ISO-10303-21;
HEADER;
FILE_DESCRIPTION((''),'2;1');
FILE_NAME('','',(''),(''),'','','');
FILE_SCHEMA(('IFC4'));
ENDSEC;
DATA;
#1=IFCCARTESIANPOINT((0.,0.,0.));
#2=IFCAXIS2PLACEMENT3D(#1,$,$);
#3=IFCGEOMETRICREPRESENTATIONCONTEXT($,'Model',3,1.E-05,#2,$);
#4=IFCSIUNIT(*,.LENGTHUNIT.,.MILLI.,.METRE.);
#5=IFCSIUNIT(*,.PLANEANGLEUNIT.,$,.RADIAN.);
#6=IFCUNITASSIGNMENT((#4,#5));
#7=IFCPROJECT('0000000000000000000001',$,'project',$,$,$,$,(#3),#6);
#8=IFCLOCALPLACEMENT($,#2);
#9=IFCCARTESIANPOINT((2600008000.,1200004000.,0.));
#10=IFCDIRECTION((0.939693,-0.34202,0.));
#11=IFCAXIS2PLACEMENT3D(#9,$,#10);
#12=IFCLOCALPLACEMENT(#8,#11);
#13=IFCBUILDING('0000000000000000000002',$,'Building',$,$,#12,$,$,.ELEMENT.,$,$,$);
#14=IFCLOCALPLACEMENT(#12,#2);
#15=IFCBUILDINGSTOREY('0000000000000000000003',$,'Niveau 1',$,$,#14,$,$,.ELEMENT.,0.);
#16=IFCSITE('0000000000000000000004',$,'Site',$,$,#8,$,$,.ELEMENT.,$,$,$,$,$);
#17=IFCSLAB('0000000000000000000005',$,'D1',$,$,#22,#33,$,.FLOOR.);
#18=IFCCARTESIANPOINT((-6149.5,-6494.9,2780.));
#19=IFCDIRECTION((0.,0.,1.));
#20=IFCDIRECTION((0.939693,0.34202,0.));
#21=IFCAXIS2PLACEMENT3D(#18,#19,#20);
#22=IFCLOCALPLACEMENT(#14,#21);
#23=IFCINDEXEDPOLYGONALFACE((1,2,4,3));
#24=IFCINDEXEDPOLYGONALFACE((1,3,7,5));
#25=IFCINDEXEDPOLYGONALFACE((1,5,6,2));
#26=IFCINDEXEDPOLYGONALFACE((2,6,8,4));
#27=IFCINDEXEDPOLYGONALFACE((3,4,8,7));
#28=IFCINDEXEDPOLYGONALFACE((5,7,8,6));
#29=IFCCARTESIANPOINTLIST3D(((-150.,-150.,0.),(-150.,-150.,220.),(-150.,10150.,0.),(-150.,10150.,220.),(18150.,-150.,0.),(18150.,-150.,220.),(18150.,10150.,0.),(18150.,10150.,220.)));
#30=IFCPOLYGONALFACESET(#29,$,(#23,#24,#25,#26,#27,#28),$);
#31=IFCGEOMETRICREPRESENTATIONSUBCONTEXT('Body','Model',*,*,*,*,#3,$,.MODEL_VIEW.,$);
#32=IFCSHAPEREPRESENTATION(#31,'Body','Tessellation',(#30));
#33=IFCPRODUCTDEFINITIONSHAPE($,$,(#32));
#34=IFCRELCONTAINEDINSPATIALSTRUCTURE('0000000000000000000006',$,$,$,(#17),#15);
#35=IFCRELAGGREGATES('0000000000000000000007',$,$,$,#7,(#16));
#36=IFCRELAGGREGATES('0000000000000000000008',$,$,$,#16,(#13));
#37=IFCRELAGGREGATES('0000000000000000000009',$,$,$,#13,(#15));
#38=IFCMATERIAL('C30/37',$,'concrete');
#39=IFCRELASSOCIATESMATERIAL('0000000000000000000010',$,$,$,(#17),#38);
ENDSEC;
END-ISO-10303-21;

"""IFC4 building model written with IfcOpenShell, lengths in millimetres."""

from ifc_helpers import new_model, si_unit, frame, origin, place, context, subcontext, project, spatial, polyline, outline, extrude, material, element, save


model = new_model("IFC4")

# Units and contexts
model_context = context("Model", 3, precision=1e-05, world=origin())
body_context = subcontext(model_context, "Body", "Model", "MODEL_VIEW")
ifc_project = project(units=[si_unit("LENGTHUNIT", "METRE", prefix="MILLI"), si_unit("PLANEANGLEUNIT", "RADIAN")], contexts=[model_context])

# Site, building, storey
site_placement = place(None, origin())
site = spatial("IfcSite", under=ifc_project, at=site_placement, Name="Site", CompositionType="ELEMENT")
building_placement = place(site_placement, frame((2600008000.0, 1200004000.0, 0.0), x_axis=(0.939693, -0.34202, 0.0)))
building = spatial("IfcBuilding", under=site, at=building_placement, Name="Building", CompositionType="ELEMENT")
storey_placement = place(building_placement, origin())
storey = spatial("IfcBuildingStorey", under=building, at=storey_placement, Name="Niveau 1", CompositionType="ELEMENT", Elevation=0.0)

# Shared definitions
ifc_material = material(Name="C30/37", Category="concrete")

# Slab
slab_placement = place(storey_placement, frame((-6149.5, -6494.9, 2780.0), z_axis=(0.0, 0.0, 1.0), x_axis=(0.939693, 0.34202, 0.0)))
element("IfcSlab", 1, at=slab_placement, inside=storey, material=ifc_material, Name="D1", PredefinedType="FLOOR", context=body_context, shape_type="SweptSolid", body=[
    extrude(outline(polyline([(-150.0, -150.0), (18150.0, -150.0), (18150.0, 10150.0), (-150.0, 10150.0), (-150.0, -150.0)])), origin(), (0.0, 0.0, 1.0), 220.0),
])

save(model, "model.ifc")
